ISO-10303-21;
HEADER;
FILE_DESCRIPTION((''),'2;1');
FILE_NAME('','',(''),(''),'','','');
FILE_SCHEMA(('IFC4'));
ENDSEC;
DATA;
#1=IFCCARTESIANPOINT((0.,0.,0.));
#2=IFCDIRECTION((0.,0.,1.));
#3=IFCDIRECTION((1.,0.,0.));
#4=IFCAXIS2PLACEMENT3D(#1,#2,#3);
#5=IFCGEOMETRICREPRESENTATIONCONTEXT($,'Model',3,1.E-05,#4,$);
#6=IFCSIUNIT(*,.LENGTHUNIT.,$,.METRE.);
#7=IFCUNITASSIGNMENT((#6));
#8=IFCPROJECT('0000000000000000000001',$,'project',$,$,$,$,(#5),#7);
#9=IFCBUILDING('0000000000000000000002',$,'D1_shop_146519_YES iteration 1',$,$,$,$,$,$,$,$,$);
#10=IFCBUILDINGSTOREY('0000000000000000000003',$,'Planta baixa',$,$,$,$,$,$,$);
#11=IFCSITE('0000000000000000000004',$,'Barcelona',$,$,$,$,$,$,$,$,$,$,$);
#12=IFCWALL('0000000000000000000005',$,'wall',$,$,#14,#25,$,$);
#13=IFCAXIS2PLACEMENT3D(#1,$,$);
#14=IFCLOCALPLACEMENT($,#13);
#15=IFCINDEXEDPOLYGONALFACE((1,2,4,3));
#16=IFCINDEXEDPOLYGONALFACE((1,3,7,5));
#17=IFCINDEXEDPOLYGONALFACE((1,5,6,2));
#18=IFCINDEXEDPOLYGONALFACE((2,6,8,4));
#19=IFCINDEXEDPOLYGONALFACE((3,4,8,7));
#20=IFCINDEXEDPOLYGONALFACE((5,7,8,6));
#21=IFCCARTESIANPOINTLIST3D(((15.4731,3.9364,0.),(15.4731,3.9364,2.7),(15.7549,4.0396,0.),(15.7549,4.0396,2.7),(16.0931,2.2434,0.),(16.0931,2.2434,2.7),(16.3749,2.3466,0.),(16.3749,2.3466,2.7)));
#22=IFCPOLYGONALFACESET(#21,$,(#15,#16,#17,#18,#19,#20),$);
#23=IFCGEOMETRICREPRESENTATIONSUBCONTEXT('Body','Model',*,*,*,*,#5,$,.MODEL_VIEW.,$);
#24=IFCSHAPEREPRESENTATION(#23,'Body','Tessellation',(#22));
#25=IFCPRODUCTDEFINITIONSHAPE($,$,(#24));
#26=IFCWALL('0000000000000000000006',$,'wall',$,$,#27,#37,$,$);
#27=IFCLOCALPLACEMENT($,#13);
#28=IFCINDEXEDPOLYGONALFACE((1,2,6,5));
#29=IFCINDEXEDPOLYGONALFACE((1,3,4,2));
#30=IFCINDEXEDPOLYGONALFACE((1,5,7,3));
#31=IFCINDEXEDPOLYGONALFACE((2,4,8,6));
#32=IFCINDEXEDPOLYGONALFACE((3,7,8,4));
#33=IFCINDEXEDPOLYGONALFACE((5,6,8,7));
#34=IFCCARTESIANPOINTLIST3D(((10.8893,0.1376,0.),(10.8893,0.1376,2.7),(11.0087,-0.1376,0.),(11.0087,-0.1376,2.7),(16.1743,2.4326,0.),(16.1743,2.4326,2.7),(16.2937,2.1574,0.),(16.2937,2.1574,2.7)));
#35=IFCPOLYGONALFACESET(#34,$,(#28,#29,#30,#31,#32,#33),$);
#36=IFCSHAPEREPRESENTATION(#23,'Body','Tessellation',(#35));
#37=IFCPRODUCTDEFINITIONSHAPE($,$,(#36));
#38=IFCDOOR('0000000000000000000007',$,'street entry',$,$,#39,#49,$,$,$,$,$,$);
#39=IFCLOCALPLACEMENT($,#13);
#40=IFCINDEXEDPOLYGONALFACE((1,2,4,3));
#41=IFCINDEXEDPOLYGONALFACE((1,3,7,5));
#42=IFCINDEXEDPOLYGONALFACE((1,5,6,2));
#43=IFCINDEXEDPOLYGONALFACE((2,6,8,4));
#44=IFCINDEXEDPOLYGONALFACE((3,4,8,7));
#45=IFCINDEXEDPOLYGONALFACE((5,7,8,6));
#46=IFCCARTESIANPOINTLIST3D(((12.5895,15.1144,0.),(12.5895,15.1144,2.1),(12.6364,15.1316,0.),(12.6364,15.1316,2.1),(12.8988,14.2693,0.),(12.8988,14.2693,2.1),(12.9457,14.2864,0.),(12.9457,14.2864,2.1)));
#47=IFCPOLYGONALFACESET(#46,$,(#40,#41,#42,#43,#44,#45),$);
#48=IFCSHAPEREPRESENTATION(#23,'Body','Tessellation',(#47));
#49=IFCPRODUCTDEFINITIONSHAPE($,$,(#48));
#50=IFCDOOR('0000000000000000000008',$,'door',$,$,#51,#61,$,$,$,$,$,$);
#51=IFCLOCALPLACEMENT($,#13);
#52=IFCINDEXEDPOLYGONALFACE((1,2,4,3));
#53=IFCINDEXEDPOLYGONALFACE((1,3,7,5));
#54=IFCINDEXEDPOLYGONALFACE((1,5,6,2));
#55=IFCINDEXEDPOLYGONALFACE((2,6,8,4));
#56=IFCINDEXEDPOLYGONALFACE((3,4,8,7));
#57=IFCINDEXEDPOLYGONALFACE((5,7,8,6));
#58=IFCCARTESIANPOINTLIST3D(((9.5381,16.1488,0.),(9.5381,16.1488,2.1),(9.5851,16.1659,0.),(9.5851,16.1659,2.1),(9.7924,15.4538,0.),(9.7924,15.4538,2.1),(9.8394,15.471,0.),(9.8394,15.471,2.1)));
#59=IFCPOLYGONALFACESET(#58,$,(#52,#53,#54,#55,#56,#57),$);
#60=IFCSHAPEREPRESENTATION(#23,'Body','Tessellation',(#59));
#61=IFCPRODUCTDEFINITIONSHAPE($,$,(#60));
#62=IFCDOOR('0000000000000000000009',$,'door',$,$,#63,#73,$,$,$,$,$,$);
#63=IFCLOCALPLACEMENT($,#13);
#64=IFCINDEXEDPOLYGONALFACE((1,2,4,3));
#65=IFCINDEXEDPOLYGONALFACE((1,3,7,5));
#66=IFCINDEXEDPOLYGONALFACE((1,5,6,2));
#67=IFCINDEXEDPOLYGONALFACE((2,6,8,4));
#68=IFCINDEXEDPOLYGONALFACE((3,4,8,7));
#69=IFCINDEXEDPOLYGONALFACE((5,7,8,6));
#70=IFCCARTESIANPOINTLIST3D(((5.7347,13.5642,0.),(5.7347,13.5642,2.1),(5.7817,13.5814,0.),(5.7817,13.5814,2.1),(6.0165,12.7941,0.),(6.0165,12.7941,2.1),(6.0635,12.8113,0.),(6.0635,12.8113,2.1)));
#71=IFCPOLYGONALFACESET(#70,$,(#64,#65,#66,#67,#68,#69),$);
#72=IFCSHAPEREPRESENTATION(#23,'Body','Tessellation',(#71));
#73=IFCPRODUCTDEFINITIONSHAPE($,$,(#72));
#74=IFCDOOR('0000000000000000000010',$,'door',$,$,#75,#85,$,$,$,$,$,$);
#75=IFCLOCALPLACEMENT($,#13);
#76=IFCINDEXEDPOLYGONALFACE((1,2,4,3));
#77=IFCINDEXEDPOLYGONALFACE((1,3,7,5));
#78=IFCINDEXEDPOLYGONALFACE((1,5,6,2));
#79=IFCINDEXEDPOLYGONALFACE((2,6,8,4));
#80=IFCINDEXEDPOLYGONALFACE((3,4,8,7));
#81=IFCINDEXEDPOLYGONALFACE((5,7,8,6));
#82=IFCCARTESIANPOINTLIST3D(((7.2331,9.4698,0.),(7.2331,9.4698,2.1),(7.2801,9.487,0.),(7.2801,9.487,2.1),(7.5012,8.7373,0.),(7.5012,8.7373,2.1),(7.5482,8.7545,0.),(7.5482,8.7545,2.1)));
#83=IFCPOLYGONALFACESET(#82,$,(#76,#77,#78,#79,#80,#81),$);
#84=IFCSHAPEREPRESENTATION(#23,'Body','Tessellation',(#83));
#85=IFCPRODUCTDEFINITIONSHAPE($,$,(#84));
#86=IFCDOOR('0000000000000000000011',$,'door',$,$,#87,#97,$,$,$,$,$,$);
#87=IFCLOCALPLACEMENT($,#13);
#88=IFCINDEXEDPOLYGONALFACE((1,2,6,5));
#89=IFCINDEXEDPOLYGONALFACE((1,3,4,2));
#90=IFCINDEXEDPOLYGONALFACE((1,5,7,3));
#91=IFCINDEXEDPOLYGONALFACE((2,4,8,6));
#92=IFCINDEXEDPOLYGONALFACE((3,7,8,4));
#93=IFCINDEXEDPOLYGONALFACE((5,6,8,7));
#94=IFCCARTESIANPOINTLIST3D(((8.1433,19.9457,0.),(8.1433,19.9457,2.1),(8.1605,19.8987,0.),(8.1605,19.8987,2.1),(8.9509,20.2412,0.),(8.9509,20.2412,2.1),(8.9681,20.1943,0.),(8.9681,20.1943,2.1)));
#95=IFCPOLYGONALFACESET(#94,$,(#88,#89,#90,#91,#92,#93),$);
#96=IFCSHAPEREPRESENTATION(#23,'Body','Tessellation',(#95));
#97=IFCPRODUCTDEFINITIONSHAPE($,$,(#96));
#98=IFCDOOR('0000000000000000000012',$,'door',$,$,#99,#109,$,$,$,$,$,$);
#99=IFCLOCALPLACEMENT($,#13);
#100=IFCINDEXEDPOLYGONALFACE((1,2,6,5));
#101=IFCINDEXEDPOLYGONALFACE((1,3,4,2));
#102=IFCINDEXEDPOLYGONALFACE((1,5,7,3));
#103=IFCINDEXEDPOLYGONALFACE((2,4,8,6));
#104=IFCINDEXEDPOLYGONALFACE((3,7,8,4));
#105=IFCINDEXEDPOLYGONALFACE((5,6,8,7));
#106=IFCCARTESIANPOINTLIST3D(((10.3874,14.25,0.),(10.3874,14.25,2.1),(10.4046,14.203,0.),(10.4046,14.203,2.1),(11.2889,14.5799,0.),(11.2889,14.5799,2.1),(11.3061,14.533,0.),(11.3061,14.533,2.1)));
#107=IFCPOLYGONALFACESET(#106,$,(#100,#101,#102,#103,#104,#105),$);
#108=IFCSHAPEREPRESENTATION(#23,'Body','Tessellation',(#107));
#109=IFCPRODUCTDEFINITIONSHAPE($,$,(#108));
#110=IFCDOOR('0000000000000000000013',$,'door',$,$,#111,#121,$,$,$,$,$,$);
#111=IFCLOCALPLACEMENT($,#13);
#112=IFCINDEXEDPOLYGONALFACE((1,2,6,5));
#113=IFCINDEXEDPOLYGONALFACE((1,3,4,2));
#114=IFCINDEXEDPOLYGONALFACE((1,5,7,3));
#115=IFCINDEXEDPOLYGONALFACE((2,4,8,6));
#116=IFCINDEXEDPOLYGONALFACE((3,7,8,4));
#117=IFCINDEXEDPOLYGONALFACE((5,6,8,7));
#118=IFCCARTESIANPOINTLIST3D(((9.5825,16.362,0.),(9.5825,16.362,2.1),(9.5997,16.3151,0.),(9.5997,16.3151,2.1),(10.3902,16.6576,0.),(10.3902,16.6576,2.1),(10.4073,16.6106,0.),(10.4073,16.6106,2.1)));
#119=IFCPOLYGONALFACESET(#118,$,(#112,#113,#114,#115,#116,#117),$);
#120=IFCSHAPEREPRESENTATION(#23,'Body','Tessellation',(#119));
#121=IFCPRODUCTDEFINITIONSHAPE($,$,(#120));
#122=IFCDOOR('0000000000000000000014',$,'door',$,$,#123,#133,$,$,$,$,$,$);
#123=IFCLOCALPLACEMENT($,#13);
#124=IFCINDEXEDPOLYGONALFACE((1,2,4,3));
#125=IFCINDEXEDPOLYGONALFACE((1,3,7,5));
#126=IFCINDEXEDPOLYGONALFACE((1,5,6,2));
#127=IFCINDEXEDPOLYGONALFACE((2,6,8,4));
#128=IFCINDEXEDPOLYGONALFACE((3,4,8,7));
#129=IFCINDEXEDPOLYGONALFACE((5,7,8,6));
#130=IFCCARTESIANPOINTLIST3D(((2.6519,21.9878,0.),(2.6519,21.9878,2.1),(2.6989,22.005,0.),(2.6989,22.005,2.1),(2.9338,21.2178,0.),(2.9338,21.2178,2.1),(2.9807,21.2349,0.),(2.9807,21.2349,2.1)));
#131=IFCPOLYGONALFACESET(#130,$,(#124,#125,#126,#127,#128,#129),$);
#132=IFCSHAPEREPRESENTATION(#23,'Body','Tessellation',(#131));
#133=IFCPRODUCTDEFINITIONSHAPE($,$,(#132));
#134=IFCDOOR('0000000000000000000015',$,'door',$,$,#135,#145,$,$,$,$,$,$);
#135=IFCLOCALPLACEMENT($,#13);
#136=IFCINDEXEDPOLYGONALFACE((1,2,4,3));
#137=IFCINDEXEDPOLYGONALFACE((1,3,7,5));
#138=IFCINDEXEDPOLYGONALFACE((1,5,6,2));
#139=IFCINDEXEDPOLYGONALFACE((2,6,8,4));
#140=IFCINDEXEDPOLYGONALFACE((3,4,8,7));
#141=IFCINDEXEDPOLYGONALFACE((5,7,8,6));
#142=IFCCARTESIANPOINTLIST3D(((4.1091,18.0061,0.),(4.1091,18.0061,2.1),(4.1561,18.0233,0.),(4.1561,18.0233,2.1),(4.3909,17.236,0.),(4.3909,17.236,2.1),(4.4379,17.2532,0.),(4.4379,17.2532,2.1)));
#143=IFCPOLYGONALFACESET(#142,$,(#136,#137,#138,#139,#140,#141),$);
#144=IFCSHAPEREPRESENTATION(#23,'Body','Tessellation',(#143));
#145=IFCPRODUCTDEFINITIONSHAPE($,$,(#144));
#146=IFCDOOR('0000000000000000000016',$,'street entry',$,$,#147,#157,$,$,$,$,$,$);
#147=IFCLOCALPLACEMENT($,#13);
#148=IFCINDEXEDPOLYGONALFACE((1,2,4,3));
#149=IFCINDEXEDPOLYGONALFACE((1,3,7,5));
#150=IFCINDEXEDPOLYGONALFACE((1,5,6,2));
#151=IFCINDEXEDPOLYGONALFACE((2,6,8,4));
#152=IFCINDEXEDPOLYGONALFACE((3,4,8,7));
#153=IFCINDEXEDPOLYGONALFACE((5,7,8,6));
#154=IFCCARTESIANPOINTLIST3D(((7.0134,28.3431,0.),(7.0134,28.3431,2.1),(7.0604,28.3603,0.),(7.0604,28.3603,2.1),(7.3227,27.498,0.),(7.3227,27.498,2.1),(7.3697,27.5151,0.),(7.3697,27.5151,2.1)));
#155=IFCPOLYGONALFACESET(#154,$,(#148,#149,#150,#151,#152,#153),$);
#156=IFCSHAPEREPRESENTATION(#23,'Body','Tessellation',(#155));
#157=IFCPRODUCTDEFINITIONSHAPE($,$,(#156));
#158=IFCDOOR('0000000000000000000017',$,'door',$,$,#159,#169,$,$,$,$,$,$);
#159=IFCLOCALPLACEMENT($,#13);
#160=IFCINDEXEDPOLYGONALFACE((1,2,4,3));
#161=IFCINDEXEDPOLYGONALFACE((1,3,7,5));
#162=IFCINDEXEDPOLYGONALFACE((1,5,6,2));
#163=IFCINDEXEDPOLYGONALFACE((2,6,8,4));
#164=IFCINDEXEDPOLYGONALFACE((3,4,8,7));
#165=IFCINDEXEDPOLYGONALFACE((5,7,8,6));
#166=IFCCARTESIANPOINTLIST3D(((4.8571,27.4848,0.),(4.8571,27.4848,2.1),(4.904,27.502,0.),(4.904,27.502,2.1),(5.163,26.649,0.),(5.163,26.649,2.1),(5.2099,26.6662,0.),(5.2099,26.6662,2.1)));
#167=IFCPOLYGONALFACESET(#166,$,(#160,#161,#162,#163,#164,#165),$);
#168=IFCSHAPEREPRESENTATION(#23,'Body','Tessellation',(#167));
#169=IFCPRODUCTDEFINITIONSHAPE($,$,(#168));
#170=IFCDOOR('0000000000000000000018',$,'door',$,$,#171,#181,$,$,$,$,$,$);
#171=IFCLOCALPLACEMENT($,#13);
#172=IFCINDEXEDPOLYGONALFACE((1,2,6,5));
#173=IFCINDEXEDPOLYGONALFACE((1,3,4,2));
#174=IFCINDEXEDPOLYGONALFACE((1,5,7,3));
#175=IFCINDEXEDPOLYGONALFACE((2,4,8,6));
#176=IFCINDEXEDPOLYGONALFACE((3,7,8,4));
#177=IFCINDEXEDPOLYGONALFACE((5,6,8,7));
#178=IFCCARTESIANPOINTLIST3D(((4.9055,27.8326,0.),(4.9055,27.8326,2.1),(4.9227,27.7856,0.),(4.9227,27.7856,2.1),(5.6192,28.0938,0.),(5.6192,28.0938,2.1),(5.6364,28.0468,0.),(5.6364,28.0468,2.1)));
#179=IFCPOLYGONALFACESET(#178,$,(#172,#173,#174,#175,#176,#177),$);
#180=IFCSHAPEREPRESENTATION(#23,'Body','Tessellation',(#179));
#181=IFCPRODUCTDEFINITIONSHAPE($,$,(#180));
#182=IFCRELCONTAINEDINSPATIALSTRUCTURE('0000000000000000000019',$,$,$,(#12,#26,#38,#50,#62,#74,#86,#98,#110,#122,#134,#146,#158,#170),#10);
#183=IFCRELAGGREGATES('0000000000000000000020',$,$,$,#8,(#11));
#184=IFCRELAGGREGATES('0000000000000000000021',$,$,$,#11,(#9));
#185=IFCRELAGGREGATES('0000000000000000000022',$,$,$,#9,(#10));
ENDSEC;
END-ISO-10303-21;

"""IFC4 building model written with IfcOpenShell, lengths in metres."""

from ifc_helpers import new_model, si_unit, origin, origin_with_axes, place, context, subcontext, project, spatial, polyline, outline, extrude, element, save


model = new_model("IFC4")

# Units and contexts
model_context = context("Model", 3, precision=1e-05, world=origin_with_axes())
body_context = subcontext(model_context, "Body", "Model", "MODEL_VIEW")
ifc_project = project(units=[si_unit("LENGTHUNIT", "METRE")], contexts=[model_context])

# Site, building, storey
site = spatial("IfcSite", under=ifc_project, Name="Barcelona")
building = spatial("IfcBuilding", under=site, Name="D1_shop_146519_YES iteration 1")
storey = spatial("IfcBuildingStorey", under=building, Name="Planta baixa")

# Walls
wall_1_placement = place(None, origin_with_axes())
element("IfcWall", 1, at=wall_1_placement, inside=storey, Name="wall", context=body_context, shape_type="SweptSolid", body=[
    extrude(outline(polyline([(15.7549, 4.0396), (16.3749, 2.3466), (16.0931, 2.2434), (15.4731, 3.9364), (15.7549, 4.0396)])), origin(), (0.0, 0.0, 1.0), 2.7),
])
wall_2_placement = place(None, origin_with_axes())
element("IfcWall", 2, at=wall_2_placement, inside=storey, Name="wall", context=body_context, shape_type="SweptSolid", body=[
    extrude(outline(polyline([(16.2937, 2.1574), (11.0087, -0.1376), (10.8893, 0.1376), (16.1743, 2.4326), (16.2937, 2.1574)])), origin(), (0.0, 0.0, 1.0), 2.7),
])

# Doors
door_1_placement = place(None, origin_with_axes())
element("IfcDoor", 3, at=door_1_placement, inside=storey, Name="street entry", context=body_context, shape_type="SweptSolid", body=[
    extrude(outline(polyline([(12.8988, 14.2693), (12.5895, 15.1144), (12.6364, 15.1316), (12.9457, 14.2864), (12.8988, 14.2693)])), origin(), (0.0, 0.0, 1.0), 2.1),
])
door_2_placement = place(None, origin_with_axes())
element("IfcDoor", 4, at=door_2_placement, inside=storey, Name="door", context=body_context, shape_type="SweptSolid", body=[
    extrude(outline(polyline([(9.7924, 15.4538), (9.5381, 16.1488), (9.5851, 16.1659), (9.8394, 15.471), (9.7924, 15.4538)])), origin(), (0.0, 0.0, 1.0), 2.1),
])
door_3_placement = place(None, origin_with_axes())
element("IfcDoor", 5, at=door_3_placement, inside=storey, Name="door", context=body_context, shape_type="SweptSolid", body=[
    extrude(outline(polyline([(5.7817, 13.5814), (6.0635, 12.8113), (6.0165, 12.7941), (5.7347, 13.5642), (5.7817, 13.5814)])), origin(), (0.0, 0.0, 1.0), 2.1),
])
door_4_placement = place(None, origin_with_axes())
element("IfcDoor", 6, at=door_4_placement, inside=storey, Name="door", context=body_context, shape_type="SweptSolid", body=[
    extrude(outline(polyline([(7.5012, 8.7373), (7.2331, 9.4698), (7.2801, 9.487), (7.5482, 8.7545), (7.5012, 8.7373)])), origin(), (0.0, 0.0, 1.0), 2.1),
])
door_5_placement = place(None, origin_with_axes())
element("IfcDoor", 7, at=door_5_placement, inside=storey, Name="door", context=body_context, shape_type="SweptSolid", body=[
    extrude(outline(polyline([(8.9681, 20.1943), (8.1605, 19.8987), (8.1433, 19.9457), (8.9509, 20.2412), (8.9681, 20.1943)])), origin(), (0.0, 0.0, 1.0), 2.1),
])
door_6_placement = place(None, origin_with_axes())
element("IfcDoor", 8, at=door_6_placement, inside=storey, Name="door", context=body_context, shape_type="SweptSolid", body=[
    extrude(outline(polyline([(10.3874, 14.25), (11.2889, 14.5799), (11.3061, 14.533), (10.4046, 14.203), (10.3874, 14.25)])), origin(), (0.0, 0.0, 1.0), 2.1),
])
door_7_placement = place(None, origin_with_axes())
element("IfcDoor", 9, at=door_7_placement, inside=storey, Name="door", context=body_context, shape_type="SweptSolid", body=[
    extrude(outline(polyline([(10.4073, 16.6106), (9.5997, 16.3151), (9.5825, 16.362), (10.3902, 16.6576), (10.4073, 16.6106)])), origin(), (0.0, 0.0, 1.0), 2.1),
])
door_8_placement = place(None, origin_with_axes())
element("IfcDoor", 10, at=door_8_placement, inside=storey, Name="door", context=body_context, shape_type="SweptSolid", body=[
    extrude(outline(polyline([(2.6989, 22.005), (2.9807, 21.2349), (2.9338, 21.2178), (2.6519, 21.9878), (2.6989, 22.005)])), origin(), (0.0, 0.0, 1.0), 2.1),
])
door_9_placement = place(None, origin_with_axes())
element("IfcDoor", 11, at=door_9_placement, inside=storey, Name="door", context=body_context, shape_type="SweptSolid", body=[
    extrude(outline(polyline([(4.1561, 18.0233), (4.4379, 17.2532), (4.3909, 17.236), (4.1091, 18.0061), (4.1561, 18.0233)])), origin(), (0.0, 0.0, 1.0), 2.1),
])
door_10_placement = place(None, origin_with_axes())
element("IfcDoor", 12, at=door_10_placement, inside=storey, Name="street entry", context=body_context, shape_type="SweptSolid", body=[
    extrude(outline(polyline([(7.3227, 27.498), (7.0134, 28.3431), (7.0604, 28.3603), (7.3697, 27.5151), (7.3227, 27.498)])), origin(), (0.0, 0.0, 1.0), 2.1),
])
door_11_placement = place(None, origin_with_axes())
element("IfcDoor", 13, at=door_11_placement, inside=storey, Name="door", context=body_context, shape_type="SweptSolid", body=[
    extrude(outline(polyline([(4.904, 27.502), (5.2099, 26.6662), (5.163, 26.649), (4.8571, 27.4848), (4.904, 27.502)])), origin(), (0.0, 0.0, 1.0), 2.1),
])
door_12_placement = place(None, origin_with_axes())
element("IfcDoor", 14, at=door_12_placement, inside=storey, Name="door", context=body_context, shape_type="SweptSolid", body=[
    extrude(outline(polyline([(5.6364, 28.0468), (4.9227, 27.7856), (4.9055, 27.8326), (5.6192, 28.0938), (5.6364, 28.0468)])), origin(), (0.0, 0.0, 1.0), 2.1),
])

save(model, "model.ifc")
